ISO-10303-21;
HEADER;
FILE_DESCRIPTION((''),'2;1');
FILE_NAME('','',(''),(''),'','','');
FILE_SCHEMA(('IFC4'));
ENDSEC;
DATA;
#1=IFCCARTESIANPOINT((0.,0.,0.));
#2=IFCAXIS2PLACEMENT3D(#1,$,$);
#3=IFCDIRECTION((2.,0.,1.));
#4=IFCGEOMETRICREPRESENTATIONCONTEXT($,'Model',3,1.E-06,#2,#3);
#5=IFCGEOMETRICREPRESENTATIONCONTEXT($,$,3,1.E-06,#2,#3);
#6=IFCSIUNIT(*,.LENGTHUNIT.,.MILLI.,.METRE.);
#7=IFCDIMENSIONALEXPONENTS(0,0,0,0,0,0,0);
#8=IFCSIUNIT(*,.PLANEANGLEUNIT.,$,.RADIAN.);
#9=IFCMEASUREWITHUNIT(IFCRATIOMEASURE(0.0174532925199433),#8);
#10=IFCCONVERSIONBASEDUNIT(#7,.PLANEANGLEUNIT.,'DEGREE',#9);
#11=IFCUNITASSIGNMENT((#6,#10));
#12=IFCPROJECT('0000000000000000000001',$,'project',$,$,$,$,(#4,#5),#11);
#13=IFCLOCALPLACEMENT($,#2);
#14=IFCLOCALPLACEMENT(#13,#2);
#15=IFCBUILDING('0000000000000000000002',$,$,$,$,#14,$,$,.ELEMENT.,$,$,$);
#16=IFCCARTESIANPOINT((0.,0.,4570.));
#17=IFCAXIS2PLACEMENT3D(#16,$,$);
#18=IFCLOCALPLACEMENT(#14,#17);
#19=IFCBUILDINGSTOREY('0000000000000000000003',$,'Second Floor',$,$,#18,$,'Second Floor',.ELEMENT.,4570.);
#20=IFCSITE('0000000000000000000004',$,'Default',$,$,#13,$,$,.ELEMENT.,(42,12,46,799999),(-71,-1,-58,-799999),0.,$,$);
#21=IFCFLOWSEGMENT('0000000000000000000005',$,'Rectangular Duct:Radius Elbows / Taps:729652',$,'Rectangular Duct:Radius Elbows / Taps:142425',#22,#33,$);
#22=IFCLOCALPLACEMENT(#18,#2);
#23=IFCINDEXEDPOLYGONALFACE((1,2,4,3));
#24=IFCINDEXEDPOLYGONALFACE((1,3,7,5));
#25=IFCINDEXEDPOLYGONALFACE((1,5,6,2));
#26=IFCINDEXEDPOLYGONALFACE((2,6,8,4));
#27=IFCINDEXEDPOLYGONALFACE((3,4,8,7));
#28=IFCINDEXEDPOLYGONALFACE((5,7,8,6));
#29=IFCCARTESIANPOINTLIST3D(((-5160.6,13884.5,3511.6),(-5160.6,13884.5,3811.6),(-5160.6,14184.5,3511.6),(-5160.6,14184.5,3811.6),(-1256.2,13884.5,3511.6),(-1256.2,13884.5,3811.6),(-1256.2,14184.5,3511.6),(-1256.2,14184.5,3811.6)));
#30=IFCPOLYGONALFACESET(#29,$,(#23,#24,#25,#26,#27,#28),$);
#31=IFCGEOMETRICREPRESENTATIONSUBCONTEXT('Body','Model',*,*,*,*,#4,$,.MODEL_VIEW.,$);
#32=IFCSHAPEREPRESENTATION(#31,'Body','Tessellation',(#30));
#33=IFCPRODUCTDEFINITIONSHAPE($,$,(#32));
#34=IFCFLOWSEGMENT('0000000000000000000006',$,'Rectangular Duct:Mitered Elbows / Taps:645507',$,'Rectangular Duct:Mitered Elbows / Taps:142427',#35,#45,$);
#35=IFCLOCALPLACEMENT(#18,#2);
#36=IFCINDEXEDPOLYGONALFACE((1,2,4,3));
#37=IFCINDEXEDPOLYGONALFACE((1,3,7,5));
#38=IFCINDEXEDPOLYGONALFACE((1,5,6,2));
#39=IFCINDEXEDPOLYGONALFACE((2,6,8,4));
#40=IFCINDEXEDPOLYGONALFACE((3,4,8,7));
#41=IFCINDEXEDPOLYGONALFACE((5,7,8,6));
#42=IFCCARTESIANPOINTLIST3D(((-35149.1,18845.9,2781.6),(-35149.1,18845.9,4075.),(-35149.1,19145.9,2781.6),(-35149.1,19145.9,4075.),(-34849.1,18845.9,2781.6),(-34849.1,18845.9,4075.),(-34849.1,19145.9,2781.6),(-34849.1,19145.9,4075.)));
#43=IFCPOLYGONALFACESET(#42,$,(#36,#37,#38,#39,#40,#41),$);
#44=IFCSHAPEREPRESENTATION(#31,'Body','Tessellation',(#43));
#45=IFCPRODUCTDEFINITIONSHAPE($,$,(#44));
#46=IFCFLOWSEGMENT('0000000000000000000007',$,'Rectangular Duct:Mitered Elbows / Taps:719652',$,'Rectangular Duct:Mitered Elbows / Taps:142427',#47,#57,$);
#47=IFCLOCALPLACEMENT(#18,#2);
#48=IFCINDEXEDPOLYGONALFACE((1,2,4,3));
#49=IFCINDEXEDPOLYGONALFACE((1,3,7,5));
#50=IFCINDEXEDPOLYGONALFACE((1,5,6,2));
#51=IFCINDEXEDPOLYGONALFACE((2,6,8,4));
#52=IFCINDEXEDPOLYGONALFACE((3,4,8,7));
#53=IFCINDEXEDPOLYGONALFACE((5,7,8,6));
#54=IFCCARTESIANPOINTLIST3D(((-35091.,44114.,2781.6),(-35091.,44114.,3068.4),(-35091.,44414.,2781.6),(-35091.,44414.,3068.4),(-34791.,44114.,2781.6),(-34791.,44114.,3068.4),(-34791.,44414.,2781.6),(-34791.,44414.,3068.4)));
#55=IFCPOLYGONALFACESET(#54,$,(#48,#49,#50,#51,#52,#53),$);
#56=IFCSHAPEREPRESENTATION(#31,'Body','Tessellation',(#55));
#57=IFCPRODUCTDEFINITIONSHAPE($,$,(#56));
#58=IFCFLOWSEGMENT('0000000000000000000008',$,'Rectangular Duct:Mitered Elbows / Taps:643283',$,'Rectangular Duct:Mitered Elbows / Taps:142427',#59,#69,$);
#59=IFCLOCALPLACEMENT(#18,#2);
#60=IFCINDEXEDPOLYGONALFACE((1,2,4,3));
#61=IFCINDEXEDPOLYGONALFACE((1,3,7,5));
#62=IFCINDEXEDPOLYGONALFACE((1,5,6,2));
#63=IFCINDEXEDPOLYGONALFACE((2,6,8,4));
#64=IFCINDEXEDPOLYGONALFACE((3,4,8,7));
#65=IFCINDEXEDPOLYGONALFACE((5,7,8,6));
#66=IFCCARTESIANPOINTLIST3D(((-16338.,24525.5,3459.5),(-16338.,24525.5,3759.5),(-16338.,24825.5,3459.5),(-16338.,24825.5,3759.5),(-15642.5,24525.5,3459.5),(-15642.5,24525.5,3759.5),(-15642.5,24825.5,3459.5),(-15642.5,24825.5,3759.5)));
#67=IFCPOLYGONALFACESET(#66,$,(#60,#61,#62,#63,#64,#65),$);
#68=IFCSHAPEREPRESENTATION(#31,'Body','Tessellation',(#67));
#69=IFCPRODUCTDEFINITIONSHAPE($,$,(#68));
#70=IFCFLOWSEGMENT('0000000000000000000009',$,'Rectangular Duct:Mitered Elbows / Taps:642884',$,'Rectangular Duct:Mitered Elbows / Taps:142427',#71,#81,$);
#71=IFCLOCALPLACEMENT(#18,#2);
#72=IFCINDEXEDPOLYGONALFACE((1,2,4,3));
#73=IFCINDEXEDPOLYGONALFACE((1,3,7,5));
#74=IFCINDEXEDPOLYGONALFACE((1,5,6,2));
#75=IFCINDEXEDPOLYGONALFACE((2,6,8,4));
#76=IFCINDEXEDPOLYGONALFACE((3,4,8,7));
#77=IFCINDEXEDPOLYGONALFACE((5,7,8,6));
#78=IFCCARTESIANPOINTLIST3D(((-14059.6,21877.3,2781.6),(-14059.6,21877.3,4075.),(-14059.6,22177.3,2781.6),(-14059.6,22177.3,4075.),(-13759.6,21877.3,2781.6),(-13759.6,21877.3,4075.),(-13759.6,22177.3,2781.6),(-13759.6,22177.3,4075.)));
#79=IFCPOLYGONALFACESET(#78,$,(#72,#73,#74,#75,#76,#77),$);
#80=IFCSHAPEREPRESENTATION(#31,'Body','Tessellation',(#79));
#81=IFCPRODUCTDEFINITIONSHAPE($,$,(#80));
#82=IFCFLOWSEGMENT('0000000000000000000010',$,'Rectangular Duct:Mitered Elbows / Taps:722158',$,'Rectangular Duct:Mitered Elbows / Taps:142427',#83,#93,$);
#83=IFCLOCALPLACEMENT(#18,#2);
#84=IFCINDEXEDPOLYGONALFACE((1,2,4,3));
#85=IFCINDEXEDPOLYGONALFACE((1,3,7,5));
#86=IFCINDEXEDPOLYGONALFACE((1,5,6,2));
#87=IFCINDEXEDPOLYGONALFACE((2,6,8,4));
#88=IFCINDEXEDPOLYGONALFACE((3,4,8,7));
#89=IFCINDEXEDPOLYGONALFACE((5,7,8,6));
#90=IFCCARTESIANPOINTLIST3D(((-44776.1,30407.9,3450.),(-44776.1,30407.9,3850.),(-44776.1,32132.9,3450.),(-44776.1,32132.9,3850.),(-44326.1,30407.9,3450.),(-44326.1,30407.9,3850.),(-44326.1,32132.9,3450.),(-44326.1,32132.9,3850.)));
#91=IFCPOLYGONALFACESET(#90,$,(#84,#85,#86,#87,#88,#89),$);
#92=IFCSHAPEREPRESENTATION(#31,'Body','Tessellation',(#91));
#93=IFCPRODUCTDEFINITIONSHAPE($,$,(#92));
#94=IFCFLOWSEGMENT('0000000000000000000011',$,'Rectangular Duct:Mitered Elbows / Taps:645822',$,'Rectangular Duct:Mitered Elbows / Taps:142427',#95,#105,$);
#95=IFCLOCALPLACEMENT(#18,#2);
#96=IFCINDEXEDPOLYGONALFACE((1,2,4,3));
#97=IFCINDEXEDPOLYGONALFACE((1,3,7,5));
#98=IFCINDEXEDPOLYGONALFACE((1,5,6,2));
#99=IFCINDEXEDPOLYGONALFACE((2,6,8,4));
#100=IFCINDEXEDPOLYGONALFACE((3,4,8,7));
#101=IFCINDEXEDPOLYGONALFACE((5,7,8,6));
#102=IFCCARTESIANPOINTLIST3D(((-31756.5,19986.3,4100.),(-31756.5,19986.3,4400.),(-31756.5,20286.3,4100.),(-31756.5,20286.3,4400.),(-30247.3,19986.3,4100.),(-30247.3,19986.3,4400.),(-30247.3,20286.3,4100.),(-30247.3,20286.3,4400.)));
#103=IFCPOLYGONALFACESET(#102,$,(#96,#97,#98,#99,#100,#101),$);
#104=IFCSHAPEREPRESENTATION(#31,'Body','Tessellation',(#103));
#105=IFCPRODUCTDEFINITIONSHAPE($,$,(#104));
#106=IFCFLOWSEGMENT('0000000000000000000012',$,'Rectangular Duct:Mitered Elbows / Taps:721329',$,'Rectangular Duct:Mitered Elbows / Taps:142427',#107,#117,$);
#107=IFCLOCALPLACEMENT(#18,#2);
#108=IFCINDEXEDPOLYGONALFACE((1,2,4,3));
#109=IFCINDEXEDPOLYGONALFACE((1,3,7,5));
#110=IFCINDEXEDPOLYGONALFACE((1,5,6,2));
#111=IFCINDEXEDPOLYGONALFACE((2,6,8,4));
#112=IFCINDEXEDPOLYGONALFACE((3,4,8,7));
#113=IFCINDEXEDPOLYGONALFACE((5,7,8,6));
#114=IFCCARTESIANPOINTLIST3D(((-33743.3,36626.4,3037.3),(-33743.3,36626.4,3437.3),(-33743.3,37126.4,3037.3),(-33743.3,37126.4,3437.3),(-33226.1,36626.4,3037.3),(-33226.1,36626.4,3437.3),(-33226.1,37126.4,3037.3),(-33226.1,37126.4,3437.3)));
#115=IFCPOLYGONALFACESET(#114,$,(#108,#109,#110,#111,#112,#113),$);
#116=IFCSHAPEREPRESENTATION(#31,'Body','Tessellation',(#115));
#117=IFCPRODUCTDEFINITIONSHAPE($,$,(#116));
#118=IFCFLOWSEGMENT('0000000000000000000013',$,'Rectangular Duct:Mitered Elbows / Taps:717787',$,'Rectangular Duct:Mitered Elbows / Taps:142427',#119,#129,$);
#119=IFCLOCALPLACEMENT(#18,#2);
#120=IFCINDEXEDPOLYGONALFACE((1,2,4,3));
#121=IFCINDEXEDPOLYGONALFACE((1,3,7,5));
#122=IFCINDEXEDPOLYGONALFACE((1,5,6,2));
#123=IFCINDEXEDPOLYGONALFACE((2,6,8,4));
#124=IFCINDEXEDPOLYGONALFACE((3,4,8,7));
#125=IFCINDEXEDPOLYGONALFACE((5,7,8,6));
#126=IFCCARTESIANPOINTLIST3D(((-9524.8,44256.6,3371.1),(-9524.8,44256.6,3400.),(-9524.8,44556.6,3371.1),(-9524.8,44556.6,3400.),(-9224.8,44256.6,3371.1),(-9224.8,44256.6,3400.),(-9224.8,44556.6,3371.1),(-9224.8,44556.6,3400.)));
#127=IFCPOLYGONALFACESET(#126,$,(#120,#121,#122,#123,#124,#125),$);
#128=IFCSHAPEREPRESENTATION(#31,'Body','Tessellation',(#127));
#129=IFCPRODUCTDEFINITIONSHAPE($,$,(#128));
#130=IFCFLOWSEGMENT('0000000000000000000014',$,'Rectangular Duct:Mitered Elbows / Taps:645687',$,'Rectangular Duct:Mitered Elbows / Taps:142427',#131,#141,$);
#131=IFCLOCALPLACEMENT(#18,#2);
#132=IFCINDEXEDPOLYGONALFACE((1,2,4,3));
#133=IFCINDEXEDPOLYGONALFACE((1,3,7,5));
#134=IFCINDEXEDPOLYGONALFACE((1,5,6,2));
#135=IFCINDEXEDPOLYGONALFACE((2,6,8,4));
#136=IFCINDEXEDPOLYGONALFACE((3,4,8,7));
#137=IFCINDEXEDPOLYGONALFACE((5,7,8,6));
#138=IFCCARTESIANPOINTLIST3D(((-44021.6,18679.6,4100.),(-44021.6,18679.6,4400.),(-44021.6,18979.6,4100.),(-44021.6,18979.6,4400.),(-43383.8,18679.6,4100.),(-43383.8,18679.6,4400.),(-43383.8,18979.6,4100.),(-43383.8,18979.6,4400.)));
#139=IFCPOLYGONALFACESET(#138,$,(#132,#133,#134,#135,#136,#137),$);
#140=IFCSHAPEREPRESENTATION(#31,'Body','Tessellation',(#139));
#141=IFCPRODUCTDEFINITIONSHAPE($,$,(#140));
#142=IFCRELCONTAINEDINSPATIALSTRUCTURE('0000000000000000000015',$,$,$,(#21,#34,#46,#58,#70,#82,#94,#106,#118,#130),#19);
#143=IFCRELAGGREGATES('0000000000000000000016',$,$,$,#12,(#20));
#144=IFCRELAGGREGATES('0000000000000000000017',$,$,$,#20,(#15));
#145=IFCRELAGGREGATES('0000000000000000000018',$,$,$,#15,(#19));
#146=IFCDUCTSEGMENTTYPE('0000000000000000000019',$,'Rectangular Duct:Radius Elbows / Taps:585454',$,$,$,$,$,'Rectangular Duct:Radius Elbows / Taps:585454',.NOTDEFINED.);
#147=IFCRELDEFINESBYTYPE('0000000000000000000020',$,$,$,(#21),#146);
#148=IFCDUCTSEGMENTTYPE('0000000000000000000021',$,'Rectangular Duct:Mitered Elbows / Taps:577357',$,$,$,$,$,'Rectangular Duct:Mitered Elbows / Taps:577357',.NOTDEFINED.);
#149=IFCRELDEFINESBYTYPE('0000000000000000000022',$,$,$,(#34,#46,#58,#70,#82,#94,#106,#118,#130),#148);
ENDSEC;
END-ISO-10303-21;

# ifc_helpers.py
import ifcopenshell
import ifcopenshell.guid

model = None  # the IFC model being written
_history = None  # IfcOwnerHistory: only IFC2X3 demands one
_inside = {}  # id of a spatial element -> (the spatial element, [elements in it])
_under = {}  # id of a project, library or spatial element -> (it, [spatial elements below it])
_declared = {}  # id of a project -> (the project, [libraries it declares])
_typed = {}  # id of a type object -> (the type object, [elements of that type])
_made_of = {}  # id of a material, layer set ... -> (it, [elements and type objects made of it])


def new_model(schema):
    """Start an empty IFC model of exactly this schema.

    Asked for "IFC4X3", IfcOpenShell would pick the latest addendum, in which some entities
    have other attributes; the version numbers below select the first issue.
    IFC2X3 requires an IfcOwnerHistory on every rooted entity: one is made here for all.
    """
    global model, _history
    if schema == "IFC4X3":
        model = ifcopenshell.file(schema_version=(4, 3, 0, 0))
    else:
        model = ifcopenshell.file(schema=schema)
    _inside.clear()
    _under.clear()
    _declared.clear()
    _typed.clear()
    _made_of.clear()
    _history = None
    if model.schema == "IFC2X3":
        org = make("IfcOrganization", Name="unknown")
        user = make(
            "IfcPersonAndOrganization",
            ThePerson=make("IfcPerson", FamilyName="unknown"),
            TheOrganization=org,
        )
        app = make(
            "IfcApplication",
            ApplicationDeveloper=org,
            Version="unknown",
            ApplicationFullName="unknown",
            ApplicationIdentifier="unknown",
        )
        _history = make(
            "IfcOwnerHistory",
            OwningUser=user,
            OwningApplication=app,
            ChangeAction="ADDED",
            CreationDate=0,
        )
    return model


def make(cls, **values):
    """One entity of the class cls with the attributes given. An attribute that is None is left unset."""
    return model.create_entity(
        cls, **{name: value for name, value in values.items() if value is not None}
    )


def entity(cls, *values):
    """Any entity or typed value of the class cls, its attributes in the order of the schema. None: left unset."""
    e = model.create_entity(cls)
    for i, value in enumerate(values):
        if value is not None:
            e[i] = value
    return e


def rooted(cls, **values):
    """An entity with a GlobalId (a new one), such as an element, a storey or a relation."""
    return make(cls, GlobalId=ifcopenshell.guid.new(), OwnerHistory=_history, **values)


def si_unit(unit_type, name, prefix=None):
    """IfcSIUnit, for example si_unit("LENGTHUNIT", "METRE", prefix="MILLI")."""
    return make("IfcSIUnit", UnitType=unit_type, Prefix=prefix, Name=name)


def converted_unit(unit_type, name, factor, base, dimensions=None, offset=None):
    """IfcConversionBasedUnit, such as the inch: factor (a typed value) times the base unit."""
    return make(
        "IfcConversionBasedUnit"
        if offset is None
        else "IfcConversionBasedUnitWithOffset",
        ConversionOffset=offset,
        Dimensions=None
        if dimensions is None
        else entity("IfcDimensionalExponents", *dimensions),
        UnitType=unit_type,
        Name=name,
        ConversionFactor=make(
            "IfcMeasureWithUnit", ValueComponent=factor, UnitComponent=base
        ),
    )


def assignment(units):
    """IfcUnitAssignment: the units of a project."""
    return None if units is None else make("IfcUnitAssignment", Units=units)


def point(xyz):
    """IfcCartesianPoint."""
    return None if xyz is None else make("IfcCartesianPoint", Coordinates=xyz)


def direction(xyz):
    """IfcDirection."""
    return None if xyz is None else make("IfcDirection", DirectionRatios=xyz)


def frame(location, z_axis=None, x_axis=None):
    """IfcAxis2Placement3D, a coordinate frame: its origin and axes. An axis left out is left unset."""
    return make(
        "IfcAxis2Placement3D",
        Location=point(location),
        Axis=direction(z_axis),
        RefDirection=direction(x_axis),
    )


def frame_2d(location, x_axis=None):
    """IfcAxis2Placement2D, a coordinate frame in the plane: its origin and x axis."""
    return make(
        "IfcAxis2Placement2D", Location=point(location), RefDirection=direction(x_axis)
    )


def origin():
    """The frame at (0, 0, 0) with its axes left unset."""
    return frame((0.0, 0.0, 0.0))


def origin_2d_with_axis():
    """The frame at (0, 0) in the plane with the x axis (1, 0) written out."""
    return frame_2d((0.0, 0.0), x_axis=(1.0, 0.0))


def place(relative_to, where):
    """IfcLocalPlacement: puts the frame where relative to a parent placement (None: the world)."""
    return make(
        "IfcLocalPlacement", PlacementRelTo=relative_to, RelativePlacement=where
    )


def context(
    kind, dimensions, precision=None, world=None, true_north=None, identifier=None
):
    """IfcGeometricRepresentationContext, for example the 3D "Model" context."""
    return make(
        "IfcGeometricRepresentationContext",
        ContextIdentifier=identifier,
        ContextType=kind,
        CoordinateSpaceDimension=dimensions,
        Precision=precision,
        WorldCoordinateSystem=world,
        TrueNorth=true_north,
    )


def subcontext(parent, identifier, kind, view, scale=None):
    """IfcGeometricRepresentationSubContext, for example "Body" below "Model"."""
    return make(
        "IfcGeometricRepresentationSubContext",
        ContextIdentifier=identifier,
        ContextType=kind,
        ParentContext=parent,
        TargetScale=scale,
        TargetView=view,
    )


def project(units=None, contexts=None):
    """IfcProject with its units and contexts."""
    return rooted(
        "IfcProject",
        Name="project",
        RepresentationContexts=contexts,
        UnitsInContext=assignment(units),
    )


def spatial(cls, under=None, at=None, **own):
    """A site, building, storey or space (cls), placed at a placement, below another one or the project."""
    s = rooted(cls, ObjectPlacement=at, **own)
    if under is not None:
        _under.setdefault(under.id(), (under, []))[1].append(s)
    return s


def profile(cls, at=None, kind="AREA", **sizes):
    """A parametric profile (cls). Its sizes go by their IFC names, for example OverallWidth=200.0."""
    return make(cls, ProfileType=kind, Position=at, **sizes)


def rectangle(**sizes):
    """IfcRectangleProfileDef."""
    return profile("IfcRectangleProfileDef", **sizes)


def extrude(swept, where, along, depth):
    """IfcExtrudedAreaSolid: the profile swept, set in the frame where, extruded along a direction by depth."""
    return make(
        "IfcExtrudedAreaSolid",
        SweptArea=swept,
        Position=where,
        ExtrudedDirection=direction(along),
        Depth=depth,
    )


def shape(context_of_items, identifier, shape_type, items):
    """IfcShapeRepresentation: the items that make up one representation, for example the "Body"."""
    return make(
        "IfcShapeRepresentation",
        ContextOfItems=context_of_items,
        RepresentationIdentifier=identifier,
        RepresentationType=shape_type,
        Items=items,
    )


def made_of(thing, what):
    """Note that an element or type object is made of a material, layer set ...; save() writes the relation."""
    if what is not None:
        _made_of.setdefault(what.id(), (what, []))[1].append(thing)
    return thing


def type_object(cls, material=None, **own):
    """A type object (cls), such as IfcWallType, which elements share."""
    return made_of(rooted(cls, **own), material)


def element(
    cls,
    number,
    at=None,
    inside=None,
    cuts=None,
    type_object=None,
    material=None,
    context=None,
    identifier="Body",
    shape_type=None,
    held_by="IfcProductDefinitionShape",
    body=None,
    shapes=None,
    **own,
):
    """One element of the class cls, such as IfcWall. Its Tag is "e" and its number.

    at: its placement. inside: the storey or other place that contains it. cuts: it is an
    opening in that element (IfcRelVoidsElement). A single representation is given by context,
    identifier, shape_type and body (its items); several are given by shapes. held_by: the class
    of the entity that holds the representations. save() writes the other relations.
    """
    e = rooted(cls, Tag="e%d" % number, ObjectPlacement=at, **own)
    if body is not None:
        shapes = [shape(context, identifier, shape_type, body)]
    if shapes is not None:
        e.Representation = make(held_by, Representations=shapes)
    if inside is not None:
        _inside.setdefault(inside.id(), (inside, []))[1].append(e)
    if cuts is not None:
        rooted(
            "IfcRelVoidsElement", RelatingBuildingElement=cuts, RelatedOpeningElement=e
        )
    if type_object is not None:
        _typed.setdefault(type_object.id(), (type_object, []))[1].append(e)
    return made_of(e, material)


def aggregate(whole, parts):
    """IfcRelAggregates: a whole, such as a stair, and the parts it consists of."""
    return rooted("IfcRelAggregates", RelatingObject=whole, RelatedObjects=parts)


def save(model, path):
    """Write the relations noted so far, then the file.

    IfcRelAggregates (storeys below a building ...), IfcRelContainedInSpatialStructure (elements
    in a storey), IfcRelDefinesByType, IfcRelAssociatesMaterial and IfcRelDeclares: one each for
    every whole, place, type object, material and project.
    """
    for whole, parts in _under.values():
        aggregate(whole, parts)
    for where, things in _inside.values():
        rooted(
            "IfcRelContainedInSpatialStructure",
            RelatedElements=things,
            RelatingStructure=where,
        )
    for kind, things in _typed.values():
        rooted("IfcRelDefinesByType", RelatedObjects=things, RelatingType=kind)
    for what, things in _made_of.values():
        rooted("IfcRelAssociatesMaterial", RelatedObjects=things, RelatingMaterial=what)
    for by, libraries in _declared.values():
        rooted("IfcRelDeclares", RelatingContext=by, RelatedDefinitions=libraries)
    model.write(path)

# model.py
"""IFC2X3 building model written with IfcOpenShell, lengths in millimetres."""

from ifc_helpers import new_model, entity, si_unit, converted_unit, direction, frame, frame_2d, origin, origin_2d_with_axis, place, context, subcontext, project, spatial, rectangle, extrude, type_object, element, save


model = new_model("IFC2X3")

# Units and contexts
model_context = context("Model", 3, precision=1e-06, world=origin(), true_north=direction((2.0, 0.0, 1.0)))
context_of_model = context(None, 3, precision=1e-06, world=origin(), true_north=direction((2.0, 0.0, 1.0)))
body_context = subcontext(model_context, "Body", "Model", "MODEL_VIEW")
ifc_project = project(units=[si_unit("LENGTHUNIT", "METRE", prefix="MILLI"), converted_unit("PLANEANGLEUNIT", "DEGREE", entity("IfcRatioMeasure", 0.0174532925199433), si_unit("PLANEANGLEUNIT", "RADIAN"), dimensions=[0, 0, 0, 0, 0, 0, 0])], contexts=[model_context, context_of_model])

# Site, building, storey
site_placement = place(None, origin())
site = spatial("IfcSite", under=ifc_project, at=site_placement, Name="Default", CompositionType="ELEMENT", RefLatitude=(42, 12, 46, 799999), RefLongitude=(-71, -1, -58, -799999), RefElevation=0.0)
building_placement = place(site_placement, origin())
building = spatial("IfcBuilding", under=site, at=building_placement, CompositionType="ELEMENT")
storey_placement = place(building_placement, frame((0.0, 0.0, 4570.0)))
storey = spatial("IfcBuildingStorey", under=building, at=storey_placement, Name="Second Floor", LongName="Second Floor", CompositionType="ELEMENT", Elevation=4570.0)

# Flow segments
duct_segment_type_1 = type_object("IfcDuctSegmentType", Name="Rectangular Duct:Radius Elbows / Taps:585454", ElementType="Rectangular Duct:Radius Elbows / Taps:585454", PredefinedType="NOTDEFINED")
flow_segment_1_placement = place(storey_placement, origin())
element("IfcFlowSegment", 1, at=flow_segment_1_placement, inside=storey, type_object=duct_segment_type_1, Name="Rectangular Duct:Radius Elbows / Taps:729652", ObjectType="Rectangular Duct:Radius Elbows / Taps:142425", context=body_context, shape_type="SweptSolid", body=[
    extrude(rectangle(XDim=3904.4, YDim=300.0, at=frame_2d((0.0, 0.0), x_axis=(1.0, 0.0))), frame((-3208.4, 14034.5, 3511.6), z_axis=(0.0, 0.0, 1.0), x_axis=(-1.0, 0.0, 0.0)), (0.0, 0.0, 1.0), 300.0),
])
duct_segment_type_2 = type_object("IfcDuctSegmentType", Name="Rectangular Duct:Mitered Elbows / Taps:577357", ElementType="Rectangular Duct:Mitered Elbows / Taps:577357", PredefinedType="NOTDEFINED")
flow_segment_2_placement = place(storey_placement, origin())
element("IfcFlowSegment", 2, at=flow_segment_2_placement, inside=storey, type_object=duct_segment_type_2, Name="Rectangular Duct:Mitered Elbows / Taps:645507", ObjectType="Rectangular Duct:Mitered Elbows / Taps:142427", context=body_context, shape_type="SweptSolid", body=[
    extrude(rectangle(XDim=300.0, YDim=300.0, at=origin_2d_with_axis()), frame((-34999.1, 18995.9, 2781.6), z_axis=(0.0, 0.0, 1.0), x_axis=(0.0, 1.0, 0.0)), (0.0, 0.0, 1.0), 1293.4),
])
flow_segment_3_placement = place(storey_placement, origin())
element("IfcFlowSegment", 3, at=flow_segment_3_placement, inside=storey, type_object=duct_segment_type_2, Name="Rectangular Duct:Mitered Elbows / Taps:719652", ObjectType="Rectangular Duct:Mitered Elbows / Taps:142427", context=body_context, shape_type="SweptSolid", body=[
    extrude(rectangle(XDim=300.0, YDim=300.0, at=origin_2d_with_axis()), frame((-34941.0, 44264.0, 2781.6), z_axis=(0.0, 0.0, 1.0), x_axis=(0.0, -1.0, 0.0)), (0.0, 0.0, 1.0), 286.8),
])
flow_segment_4_placement = place(storey_placement, origin())
element("IfcFlowSegment", 4, at=flow_segment_4_placement, inside=storey, type_object=duct_segment_type_2, Name="Rectangular Duct:Mitered Elbows / Taps:643283", ObjectType="Rectangular Duct:Mitered Elbows / Taps:142427", context=body_context, shape_type="SweptSolid", body=[
    extrude(rectangle(XDim=695.5, YDim=300.0, at=frame_2d((0.0, 0.0), x_axis=(1.0, 0.0))), frame((-15990.3, 24675.5, 3459.5), z_axis=(0.0, 0.0, 1.0), x_axis=(-1.0, 0.0, 0.0)), (0.0, 0.0, 1.0), 300.0),
])
flow_segment_5_placement = place(storey_placement, origin())
element("IfcFlowSegment", 5, at=flow_segment_5_placement, inside=storey, type_object=duct_segment_type_2, Name="Rectangular Duct:Mitered Elbows / Taps:642884", ObjectType="Rectangular Duct:Mitered Elbows / Taps:142427", context=body_context, shape_type="SweptSolid", body=[
    extrude(rectangle(XDim=300.0, YDim=300.0, at=origin_2d_with_axis()), frame((-13909.6, 22027.3, 2781.6), z_axis=(0.0, 0.0, 1.0), x_axis=(0.0, -1.0, 0.0)), (0.0, 0.0, 1.0), 1293.4),
])
flow_segment_6_placement = place(storey_placement, origin())
element("IfcFlowSegment", 6, at=flow_segment_6_placement, inside=storey, type_object=duct_segment_type_2, Name="Rectangular Duct:Mitered Elbows / Taps:722158", ObjectType="Rectangular Duct:Mitered Elbows / Taps:142427", context=body_context, shape_type="SweptSolid", body=[
    extrude(rectangle(XDim=1725.0, YDim=450.0, at=frame_2d((0.0, 0.0), x_axis=(1.0, 0.0))), frame((-44551.1, 31270.4, 3450.0), z_axis=(0.0, 0.0, 1.0), x_axis=(0.0, 1.0, 0.0)), (0.0, 0.0, 1.0), 400.0),
])
flow_segment_7_placement = place(storey_placement, origin())
element("IfcFlowSegment", 7, at=flow_segment_7_placement, inside=storey, type_object=duct_segment_type_2, Name="Rectangular Duct:Mitered Elbows / Taps:645822", ObjectType="Rectangular Duct:Mitered Elbows / Taps:142427", context=body_context, shape_type="SweptSolid", body=[
    extrude(rectangle(XDim=1509.1, YDim=300.0, at=origin_2d_with_axis()), frame((-31001.9, 20136.3, 4100.0)), (0.0, 0.0, 1.0), 300.0),
])
flow_segment_8_placement = place(storey_placement, origin())
element("IfcFlowSegment", 8, at=flow_segment_8_placement, inside=storey, type_object=duct_segment_type_2, Name="Rectangular Duct:Mitered Elbows / Taps:721329", ObjectType="Rectangular Duct:Mitered Elbows / Taps:142427", context=body_context, shape_type="SweptSolid", body=[
    extrude(rectangle(XDim=517.2, YDim=500.0, at=frame_2d((0.0, 0.0), x_axis=(1.0, 0.0))), frame((-33484.7, 36876.4, 3037.3)), (0.0, 0.0, 1.0), 400.0),
])
flow_segment_9_placement = place(storey_placement, origin())
element("IfcFlowSegment", 9, at=flow_segment_9_placement, inside=storey, type_object=duct_segment_type_2, Name="Rectangular Duct:Mitered Elbows / Taps:717787", ObjectType="Rectangular Duct:Mitered Elbows / Taps:142427", context=body_context, shape_type="SweptSolid", body=[
    extrude(rectangle(XDim=300.0, YDim=300.0, at=frame_2d((0.0, 0.0), x_axis=(1.0, 0.0))), frame((-9374.8, 44406.6, 3371.1), z_axis=(0.0, 0.0, 1.0), x_axis=(0.0, 1.0, 0.0)), (0.0, 0.0, 1.0), 28.9),
])
flow_segment_10_placement = place(storey_placement, origin())
element("IfcFlowSegment", 10, at=flow_segment_10_placement, inside=storey, type_object=duct_segment_type_2, Name="Rectangular Duct:Mitered Elbows / Taps:645687", ObjectType="Rectangular Duct:Mitered Elbows / Taps:142427", context=body_context, shape_type="SweptSolid", body=[
    extrude(rectangle(XDim=637.9, YDim=300.0, at=origin_2d_with_axis()), frame((-43702.7, 18829.6, 4100.0)), (0.0, 0.0, 1.0), 300.0),
])

save(model, "model.ifc")
